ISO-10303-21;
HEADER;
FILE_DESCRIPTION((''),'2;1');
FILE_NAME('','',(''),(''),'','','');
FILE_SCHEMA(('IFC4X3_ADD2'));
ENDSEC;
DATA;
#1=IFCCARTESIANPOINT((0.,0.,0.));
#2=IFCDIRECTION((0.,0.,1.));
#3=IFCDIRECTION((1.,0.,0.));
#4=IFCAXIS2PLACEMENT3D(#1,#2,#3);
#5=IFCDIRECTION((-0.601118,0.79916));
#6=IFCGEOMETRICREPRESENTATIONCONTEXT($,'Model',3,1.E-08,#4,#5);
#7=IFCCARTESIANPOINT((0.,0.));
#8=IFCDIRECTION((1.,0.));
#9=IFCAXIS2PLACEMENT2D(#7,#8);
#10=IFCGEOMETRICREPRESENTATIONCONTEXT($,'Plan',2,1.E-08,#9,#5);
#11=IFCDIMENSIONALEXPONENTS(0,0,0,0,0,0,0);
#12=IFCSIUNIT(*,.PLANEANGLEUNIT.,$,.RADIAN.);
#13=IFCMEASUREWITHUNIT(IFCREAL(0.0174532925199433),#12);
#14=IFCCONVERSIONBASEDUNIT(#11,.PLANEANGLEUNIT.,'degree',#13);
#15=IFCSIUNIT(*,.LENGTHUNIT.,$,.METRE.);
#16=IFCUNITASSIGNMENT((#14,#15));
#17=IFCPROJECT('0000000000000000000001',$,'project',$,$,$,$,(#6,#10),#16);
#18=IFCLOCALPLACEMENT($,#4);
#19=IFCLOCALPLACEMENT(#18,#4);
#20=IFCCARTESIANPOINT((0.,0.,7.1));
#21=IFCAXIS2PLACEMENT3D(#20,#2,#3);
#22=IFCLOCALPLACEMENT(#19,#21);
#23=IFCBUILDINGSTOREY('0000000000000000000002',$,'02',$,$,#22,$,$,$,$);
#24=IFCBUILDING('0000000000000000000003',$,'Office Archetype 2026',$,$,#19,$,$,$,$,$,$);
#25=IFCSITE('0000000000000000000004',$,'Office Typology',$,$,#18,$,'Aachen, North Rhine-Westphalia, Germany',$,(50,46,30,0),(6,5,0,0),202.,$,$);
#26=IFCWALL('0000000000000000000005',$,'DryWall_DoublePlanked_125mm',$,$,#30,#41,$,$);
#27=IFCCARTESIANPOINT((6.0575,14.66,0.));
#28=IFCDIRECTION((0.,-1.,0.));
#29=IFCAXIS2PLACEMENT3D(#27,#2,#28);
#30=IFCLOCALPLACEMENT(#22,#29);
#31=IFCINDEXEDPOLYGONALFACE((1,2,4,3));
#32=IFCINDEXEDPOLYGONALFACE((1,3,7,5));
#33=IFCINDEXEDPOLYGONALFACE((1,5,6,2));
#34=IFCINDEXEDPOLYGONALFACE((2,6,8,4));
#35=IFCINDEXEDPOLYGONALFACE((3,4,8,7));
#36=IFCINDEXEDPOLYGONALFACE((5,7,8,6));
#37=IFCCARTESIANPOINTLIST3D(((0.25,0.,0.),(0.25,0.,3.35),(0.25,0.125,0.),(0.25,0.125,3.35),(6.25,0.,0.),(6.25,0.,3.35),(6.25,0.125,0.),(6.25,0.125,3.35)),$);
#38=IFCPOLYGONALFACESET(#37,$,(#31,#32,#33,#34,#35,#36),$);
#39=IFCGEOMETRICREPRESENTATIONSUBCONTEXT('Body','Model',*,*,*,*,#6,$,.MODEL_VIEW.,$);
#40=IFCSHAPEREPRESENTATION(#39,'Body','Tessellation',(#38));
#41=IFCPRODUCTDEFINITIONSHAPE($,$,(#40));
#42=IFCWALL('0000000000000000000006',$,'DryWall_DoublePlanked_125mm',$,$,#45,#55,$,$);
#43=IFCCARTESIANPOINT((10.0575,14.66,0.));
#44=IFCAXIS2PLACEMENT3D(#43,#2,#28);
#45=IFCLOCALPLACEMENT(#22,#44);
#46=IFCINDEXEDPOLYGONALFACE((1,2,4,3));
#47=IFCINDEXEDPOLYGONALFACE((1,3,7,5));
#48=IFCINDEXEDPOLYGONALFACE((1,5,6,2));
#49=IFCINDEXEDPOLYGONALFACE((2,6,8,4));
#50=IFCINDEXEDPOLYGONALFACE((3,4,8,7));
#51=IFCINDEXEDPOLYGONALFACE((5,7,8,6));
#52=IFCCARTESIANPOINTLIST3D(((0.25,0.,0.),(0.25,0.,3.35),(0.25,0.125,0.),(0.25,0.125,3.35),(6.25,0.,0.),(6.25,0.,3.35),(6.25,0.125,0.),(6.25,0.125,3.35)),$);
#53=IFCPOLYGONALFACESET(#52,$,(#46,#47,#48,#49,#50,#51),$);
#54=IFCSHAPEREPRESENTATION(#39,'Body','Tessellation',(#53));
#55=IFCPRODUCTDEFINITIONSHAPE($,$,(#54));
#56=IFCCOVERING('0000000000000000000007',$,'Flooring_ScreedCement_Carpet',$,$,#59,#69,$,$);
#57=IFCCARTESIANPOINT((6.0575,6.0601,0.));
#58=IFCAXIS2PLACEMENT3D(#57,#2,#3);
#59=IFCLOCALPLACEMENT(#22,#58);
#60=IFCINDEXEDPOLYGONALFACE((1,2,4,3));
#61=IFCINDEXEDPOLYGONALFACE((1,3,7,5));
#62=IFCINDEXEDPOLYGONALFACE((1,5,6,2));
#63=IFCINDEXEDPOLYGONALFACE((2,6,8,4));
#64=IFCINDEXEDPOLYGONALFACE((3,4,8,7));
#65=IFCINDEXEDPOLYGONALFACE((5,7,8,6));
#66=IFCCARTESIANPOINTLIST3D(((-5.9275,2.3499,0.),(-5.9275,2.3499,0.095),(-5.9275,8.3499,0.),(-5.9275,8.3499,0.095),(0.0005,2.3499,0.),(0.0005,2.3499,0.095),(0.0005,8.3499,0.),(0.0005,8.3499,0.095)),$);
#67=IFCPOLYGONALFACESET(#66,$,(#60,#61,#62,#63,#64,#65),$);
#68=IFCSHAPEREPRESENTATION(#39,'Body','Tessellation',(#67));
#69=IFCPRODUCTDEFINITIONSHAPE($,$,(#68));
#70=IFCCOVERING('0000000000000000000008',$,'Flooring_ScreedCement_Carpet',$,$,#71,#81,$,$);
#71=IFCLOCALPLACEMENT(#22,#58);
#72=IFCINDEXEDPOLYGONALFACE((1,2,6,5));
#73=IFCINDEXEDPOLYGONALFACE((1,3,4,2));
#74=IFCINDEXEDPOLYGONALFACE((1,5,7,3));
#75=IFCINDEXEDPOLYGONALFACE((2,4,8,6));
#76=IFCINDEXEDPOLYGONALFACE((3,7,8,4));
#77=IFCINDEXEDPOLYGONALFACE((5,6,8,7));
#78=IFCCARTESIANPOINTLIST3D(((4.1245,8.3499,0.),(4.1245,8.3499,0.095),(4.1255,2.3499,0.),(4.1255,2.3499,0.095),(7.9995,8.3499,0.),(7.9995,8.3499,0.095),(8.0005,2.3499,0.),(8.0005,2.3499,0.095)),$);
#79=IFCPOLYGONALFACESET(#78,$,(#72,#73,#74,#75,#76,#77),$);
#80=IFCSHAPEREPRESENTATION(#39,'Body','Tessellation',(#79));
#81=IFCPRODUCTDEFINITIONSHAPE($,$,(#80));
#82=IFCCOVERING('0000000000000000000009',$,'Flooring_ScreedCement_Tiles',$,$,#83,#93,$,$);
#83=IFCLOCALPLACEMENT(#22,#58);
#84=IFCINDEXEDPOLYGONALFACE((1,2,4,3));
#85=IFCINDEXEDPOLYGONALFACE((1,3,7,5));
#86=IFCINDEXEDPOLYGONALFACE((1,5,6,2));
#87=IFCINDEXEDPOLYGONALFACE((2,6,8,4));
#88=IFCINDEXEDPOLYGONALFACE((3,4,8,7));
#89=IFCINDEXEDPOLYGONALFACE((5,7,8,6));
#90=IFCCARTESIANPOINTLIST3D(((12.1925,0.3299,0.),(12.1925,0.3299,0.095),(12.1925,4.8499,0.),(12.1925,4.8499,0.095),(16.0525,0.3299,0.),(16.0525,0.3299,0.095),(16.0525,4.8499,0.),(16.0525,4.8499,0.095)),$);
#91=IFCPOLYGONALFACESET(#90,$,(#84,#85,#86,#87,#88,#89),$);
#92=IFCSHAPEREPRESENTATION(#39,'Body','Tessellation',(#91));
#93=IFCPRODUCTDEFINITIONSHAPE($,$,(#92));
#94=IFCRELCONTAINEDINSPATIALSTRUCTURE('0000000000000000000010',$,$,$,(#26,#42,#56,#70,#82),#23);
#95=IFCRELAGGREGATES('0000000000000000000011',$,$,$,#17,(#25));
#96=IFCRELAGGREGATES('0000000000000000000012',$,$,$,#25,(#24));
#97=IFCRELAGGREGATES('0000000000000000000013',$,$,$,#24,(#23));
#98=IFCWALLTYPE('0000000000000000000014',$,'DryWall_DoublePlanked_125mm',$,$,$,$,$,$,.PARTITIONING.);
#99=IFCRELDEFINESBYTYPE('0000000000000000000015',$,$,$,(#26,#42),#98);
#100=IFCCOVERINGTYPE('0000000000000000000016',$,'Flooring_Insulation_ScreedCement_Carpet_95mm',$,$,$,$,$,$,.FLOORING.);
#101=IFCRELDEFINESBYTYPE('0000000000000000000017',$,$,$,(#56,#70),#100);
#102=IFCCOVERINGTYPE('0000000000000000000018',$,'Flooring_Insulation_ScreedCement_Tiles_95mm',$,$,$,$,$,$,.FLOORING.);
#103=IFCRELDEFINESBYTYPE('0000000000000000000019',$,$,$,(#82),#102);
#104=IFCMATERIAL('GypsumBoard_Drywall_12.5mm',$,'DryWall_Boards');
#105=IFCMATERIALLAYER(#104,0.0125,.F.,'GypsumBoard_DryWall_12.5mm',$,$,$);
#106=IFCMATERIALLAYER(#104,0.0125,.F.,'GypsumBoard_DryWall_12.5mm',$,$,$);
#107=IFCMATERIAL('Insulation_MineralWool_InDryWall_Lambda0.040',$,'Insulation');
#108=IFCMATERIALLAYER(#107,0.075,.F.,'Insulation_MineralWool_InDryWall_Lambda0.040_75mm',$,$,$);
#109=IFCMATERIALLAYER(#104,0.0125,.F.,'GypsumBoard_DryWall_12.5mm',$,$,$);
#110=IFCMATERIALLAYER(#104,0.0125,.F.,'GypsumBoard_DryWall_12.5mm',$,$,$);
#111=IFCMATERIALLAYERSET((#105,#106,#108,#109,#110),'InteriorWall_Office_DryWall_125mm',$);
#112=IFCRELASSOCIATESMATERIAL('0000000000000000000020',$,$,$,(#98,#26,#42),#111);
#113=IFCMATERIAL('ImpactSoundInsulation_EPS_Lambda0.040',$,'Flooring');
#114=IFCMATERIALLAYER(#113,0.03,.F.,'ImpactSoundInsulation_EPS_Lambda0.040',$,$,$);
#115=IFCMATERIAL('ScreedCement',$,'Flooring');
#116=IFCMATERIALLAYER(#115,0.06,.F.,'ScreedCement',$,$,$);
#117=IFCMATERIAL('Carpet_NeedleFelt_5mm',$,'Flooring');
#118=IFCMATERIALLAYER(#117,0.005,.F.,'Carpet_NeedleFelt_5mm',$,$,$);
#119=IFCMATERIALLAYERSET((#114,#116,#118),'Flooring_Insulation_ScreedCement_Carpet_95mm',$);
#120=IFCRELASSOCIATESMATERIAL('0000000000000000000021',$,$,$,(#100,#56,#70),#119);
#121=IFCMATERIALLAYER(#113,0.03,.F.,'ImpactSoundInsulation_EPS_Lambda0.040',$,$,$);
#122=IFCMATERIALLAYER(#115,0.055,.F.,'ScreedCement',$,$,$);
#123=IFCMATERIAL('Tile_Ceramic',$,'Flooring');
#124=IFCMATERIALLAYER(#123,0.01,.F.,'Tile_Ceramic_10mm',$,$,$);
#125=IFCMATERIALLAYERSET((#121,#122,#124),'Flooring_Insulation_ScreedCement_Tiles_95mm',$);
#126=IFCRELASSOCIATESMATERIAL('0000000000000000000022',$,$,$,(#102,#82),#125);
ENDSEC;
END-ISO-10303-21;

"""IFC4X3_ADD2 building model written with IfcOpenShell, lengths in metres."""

from ifc_helpers import new_model, entity, si_unit, converted_unit, direction, frame, origin_with_axes, origin_2d_with_axis, place, context, subcontext, project, spatial, line, indexed_curve, outline, extrude, material, layer, layer_set, layer_usage, type_object, element, save


model = new_model("IFC4X3_ADD2")

# Units and contexts
model_context = context("Model", 3, precision=1e-08, world=origin_with_axes(), true_north=direction((-0.601118, 0.79916)))
plan_context = context("Plan", 2, precision=1e-08, world=origin_2d_with_axis(), true_north=direction((-0.601118, 0.79916)))
body_context = subcontext(model_context, "Body", "Model", "MODEL_VIEW")
ifc_project = project(units=[converted_unit("PLANEANGLEUNIT", "degree", entity("IfcReal", 0.0174532925199433), si_unit("PLANEANGLEUNIT", "RADIAN"), dimensions=[0, 0, 0, 0, 0, 0, 0]), si_unit("LENGTHUNIT", "METRE")], contexts=[model_context, plan_context])

# Site, building, storey
site_placement = place(None, origin_with_axes())
site = spatial("IfcSite", under=ifc_project, at=site_placement, Name="Office Typology", LongName="Aachen, North Rhine-Westphalia, Germany", RefLatitude=(50, 46, 30, 0), RefLongitude=(6, 5, 0, 0), RefElevation=202.0)
building_placement = place(site_placement, origin_with_axes())
building = spatial("IfcBuilding", under=site, at=building_placement, Name="Office Archetype 2026")
storey_placement = place(building_placement, frame((0.0, 0.0, 7.1), z_axis=(0.0, 0.0, 1.0), x_axis=(1.0, 0.0, 0.0)))
storey = spatial("IfcBuildingStorey", under=building, at=storey_placement, Name="02")

# Walls
ifc_material_1 = material(Name="GypsumBoard_Drywall_12.5mm", Category="DryWall_Boards")
ifc_layer_1 = layer(ifc_material_1, 0.0125, ventilated=False, Name="GypsumBoard_DryWall_12.5mm")
ifc_layer_2 = layer(ifc_material_1, 0.0125, ventilated=False, Name="GypsumBoard_DryWall_12.5mm")
ifc_material_2 = material(Name="Insulation_MineralWool_InDryWall_Lambda0.040", Category="Insulation")
ifc_layer_3 = layer(ifc_material_2, 0.075, ventilated=False, Name="Insulation_MineralWool_InDryWall_Lambda0.040_75mm")
ifc_layer_4 = layer(ifc_material_1, 0.0125, ventilated=False, Name="GypsumBoard_DryWall_12.5mm")
ifc_layer_5 = layer(ifc_material_1, 0.0125, ventilated=False, Name="GypsumBoard_DryWall_12.5mm")
ifc_layer_set_1 = layer_set([ifc_layer_1, ifc_layer_2, ifc_layer_3, ifc_layer_4, ifc_layer_5], Name="InteriorWall_Office_DryWall_125mm")
wall_type_1 = type_object("IfcWallType", Name="DryWall_DoublePlanked_125mm", PredefinedType="PARTITIONING", material=ifc_layer_set_1)
ifc_layer_usage_1 = layer_usage(ifc_layer_set_1, "AXIS2", "POSITIVE", 0.0)
wall_1_placement = place(storey_placement, frame((6.0575, 14.66, 0.0), z_axis=(0.0, 0.0, 1.0), x_axis=(0.0, -1.0, 0.0)))
element("IfcWall", 1, at=wall_1_placement, inside=storey, type_object=wall_type_1, material=ifc_layer_usage_1, Name="DryWall_DoublePlanked_125mm", context=body_context, shape_type="SweptSolid", body=[
    extrude(outline(indexed_curve([(0.25, 0.0), (0.25, 0.125), (6.25, 0.125), (6.25, 0.0)], segments=[line(1, 2, 3, 4, 1)])), origin_with_axes(), (0.0, 0.0, 1.0), 3.35),
])
ifc_layer_usage_2 = layer_usage(ifc_layer_set_1, "AXIS2", "POSITIVE", 0.0)
wall_2_placement = place(storey_placement, frame((10.0575, 14.66, 0.0), z_axis=(0.0, 0.0, 1.0), x_axis=(0.0, -1.0, 0.0)))
element("IfcWall", 2, at=wall_2_placement, inside=storey, type_object=wall_type_1, material=ifc_layer_usage_2, Name="DryWall_DoublePlanked_125mm", context=body_context, shape_type="SweptSolid", body=[
    extrude(outline(indexed_curve([(0.25, 0.0), (0.25, 0.125), (6.25, 0.125), (6.25, 0.0)], segments=[line(1, 2, 3, 4, 1)])), origin_with_axes(), (0.0, 0.0, 1.0), 3.35),
])

# Coverings
ifc_material_3 = material(Name="ImpactSoundInsulation_EPS_Lambda0.040", Category="Flooring")
ifc_layer_6 = layer(ifc_material_3, 0.03, ventilated=False, Name="ImpactSoundInsulation_EPS_Lambda0.040")
ifc_material_4 = material(Name="ScreedCement", Category="Flooring")
ifc_layer_7 = layer(ifc_material_4, 0.06, ventilated=False, Name="ScreedCement")
ifc_material_5 = material(Name="Carpet_NeedleFelt_5mm", Category="Flooring")
ifc_layer_8 = layer(ifc_material_5, 0.005, ventilated=False, Name="Carpet_NeedleFelt_5mm")
ifc_layer_set_2 = layer_set([ifc_layer_6, ifc_layer_7, ifc_layer_8], Name="Flooring_Insulation_ScreedCement_Carpet_95mm")
ifc_layer_usage_3 = layer_usage(ifc_layer_set_2, "AXIS3", "POSITIVE", 0.0)
covering_type_1 = type_object("IfcCoveringType", Name="Flooring_Insulation_ScreedCement_Carpet_95mm", PredefinedType="FLOORING", material=ifc_layer_set_2)
covering_1_placement = place(storey_placement, frame((6.0575, 6.0601, 0.0), z_axis=(0.0, 0.0, 1.0), x_axis=(1.0, 0.0, 0.0)))
element("IfcCovering", 3, at=covering_1_placement, inside=storey, type_object=covering_type_1, material=ifc_layer_usage_3, Name="Flooring_ScreedCement_Carpet", context=body_context, shape_type="SweptSolid", body=[
    extrude(outline(indexed_curve([(-5.9275, 2.3499), (-5.9275, 8.3499), (0.0005, 8.3499), (0.0005, 2.3499)], segments=[line(1, 2, 3, 4, 1)])), origin_with_axes(), (0.0, 0.0, 1.0), 0.095),
])
ifc_layer_usage_4 = layer_usage(ifc_layer_set_2, "AXIS3", "POSITIVE", 0.0)
covering_2_placement = place(storey_placement, frame((6.0575, 6.0601, 0.0), z_axis=(0.0, 0.0, 1.0), x_axis=(1.0, 0.0, 0.0)))
element("IfcCovering", 4, at=covering_2_placement, inside=storey, type_object=covering_type_1, material=ifc_layer_usage_4, Name="Flooring_ScreedCement_Carpet", context=body_context, shape_type="SweptSolid", body=[
    extrude(outline(indexed_curve([(4.1255, 2.3499), (4.1245, 8.3499), (7.9995, 8.3499), (8.0005, 2.3499)], segments=[line(1, 2, 3, 4, 1)])), origin_with_axes(), (0.0, 0.0, 1.0), 0.095),
])
ifc_layer_9 = layer(ifc_material_3, 0.03, ventilated=False, Name="ImpactSoundInsulation_EPS_Lambda0.040")
ifc_layer_10 = layer(ifc_material_4, 0.055, ventilated=False, Name="ScreedCement")
ifc_material_6 = material(Name="Tile_Ceramic", Category="Flooring")
ifc_layer_11 = layer(ifc_material_6, 0.01, ventilated=False, Name="Tile_Ceramic_10mm")
ifc_layer_set_3 = layer_set([ifc_layer_9, ifc_layer_10, ifc_layer_11], Name="Flooring_Insulation_ScreedCement_Tiles_95mm")
ifc_layer_usage_5 = layer_usage(ifc_layer_set_3, "AXIS3", "POSITIVE", 0.0)
covering_type_2 = type_object("IfcCoveringType", Name="Flooring_Insulation_ScreedCement_Tiles_95mm", PredefinedType="FLOORING", material=ifc_layer_set_3)
covering_3_placement = place(storey_placement, frame((6.0575, 6.0601, 0.0), z_axis=(0.0, 0.0, 1.0), x_axis=(1.0, 0.0, 0.0)))
element("IfcCovering", 5, at=covering_3_placement, inside=storey, type_object=covering_type_2, material=ifc_layer_usage_5, Name="Flooring_ScreedCement_Tiles", context=body_context, shape_type="SweptSolid", body=[
    extrude(outline(indexed_curve([(12.1925, 0.3299), (12.1925, 4.8499), (16.0525, 4.8499), (16.0525, 0.3299)], segments=[line(1, 2, 3, 4, 1)])), origin_with_axes(), (0.0, 0.0, 1.0), 0.095),
])

save(model, "model.ifc")
